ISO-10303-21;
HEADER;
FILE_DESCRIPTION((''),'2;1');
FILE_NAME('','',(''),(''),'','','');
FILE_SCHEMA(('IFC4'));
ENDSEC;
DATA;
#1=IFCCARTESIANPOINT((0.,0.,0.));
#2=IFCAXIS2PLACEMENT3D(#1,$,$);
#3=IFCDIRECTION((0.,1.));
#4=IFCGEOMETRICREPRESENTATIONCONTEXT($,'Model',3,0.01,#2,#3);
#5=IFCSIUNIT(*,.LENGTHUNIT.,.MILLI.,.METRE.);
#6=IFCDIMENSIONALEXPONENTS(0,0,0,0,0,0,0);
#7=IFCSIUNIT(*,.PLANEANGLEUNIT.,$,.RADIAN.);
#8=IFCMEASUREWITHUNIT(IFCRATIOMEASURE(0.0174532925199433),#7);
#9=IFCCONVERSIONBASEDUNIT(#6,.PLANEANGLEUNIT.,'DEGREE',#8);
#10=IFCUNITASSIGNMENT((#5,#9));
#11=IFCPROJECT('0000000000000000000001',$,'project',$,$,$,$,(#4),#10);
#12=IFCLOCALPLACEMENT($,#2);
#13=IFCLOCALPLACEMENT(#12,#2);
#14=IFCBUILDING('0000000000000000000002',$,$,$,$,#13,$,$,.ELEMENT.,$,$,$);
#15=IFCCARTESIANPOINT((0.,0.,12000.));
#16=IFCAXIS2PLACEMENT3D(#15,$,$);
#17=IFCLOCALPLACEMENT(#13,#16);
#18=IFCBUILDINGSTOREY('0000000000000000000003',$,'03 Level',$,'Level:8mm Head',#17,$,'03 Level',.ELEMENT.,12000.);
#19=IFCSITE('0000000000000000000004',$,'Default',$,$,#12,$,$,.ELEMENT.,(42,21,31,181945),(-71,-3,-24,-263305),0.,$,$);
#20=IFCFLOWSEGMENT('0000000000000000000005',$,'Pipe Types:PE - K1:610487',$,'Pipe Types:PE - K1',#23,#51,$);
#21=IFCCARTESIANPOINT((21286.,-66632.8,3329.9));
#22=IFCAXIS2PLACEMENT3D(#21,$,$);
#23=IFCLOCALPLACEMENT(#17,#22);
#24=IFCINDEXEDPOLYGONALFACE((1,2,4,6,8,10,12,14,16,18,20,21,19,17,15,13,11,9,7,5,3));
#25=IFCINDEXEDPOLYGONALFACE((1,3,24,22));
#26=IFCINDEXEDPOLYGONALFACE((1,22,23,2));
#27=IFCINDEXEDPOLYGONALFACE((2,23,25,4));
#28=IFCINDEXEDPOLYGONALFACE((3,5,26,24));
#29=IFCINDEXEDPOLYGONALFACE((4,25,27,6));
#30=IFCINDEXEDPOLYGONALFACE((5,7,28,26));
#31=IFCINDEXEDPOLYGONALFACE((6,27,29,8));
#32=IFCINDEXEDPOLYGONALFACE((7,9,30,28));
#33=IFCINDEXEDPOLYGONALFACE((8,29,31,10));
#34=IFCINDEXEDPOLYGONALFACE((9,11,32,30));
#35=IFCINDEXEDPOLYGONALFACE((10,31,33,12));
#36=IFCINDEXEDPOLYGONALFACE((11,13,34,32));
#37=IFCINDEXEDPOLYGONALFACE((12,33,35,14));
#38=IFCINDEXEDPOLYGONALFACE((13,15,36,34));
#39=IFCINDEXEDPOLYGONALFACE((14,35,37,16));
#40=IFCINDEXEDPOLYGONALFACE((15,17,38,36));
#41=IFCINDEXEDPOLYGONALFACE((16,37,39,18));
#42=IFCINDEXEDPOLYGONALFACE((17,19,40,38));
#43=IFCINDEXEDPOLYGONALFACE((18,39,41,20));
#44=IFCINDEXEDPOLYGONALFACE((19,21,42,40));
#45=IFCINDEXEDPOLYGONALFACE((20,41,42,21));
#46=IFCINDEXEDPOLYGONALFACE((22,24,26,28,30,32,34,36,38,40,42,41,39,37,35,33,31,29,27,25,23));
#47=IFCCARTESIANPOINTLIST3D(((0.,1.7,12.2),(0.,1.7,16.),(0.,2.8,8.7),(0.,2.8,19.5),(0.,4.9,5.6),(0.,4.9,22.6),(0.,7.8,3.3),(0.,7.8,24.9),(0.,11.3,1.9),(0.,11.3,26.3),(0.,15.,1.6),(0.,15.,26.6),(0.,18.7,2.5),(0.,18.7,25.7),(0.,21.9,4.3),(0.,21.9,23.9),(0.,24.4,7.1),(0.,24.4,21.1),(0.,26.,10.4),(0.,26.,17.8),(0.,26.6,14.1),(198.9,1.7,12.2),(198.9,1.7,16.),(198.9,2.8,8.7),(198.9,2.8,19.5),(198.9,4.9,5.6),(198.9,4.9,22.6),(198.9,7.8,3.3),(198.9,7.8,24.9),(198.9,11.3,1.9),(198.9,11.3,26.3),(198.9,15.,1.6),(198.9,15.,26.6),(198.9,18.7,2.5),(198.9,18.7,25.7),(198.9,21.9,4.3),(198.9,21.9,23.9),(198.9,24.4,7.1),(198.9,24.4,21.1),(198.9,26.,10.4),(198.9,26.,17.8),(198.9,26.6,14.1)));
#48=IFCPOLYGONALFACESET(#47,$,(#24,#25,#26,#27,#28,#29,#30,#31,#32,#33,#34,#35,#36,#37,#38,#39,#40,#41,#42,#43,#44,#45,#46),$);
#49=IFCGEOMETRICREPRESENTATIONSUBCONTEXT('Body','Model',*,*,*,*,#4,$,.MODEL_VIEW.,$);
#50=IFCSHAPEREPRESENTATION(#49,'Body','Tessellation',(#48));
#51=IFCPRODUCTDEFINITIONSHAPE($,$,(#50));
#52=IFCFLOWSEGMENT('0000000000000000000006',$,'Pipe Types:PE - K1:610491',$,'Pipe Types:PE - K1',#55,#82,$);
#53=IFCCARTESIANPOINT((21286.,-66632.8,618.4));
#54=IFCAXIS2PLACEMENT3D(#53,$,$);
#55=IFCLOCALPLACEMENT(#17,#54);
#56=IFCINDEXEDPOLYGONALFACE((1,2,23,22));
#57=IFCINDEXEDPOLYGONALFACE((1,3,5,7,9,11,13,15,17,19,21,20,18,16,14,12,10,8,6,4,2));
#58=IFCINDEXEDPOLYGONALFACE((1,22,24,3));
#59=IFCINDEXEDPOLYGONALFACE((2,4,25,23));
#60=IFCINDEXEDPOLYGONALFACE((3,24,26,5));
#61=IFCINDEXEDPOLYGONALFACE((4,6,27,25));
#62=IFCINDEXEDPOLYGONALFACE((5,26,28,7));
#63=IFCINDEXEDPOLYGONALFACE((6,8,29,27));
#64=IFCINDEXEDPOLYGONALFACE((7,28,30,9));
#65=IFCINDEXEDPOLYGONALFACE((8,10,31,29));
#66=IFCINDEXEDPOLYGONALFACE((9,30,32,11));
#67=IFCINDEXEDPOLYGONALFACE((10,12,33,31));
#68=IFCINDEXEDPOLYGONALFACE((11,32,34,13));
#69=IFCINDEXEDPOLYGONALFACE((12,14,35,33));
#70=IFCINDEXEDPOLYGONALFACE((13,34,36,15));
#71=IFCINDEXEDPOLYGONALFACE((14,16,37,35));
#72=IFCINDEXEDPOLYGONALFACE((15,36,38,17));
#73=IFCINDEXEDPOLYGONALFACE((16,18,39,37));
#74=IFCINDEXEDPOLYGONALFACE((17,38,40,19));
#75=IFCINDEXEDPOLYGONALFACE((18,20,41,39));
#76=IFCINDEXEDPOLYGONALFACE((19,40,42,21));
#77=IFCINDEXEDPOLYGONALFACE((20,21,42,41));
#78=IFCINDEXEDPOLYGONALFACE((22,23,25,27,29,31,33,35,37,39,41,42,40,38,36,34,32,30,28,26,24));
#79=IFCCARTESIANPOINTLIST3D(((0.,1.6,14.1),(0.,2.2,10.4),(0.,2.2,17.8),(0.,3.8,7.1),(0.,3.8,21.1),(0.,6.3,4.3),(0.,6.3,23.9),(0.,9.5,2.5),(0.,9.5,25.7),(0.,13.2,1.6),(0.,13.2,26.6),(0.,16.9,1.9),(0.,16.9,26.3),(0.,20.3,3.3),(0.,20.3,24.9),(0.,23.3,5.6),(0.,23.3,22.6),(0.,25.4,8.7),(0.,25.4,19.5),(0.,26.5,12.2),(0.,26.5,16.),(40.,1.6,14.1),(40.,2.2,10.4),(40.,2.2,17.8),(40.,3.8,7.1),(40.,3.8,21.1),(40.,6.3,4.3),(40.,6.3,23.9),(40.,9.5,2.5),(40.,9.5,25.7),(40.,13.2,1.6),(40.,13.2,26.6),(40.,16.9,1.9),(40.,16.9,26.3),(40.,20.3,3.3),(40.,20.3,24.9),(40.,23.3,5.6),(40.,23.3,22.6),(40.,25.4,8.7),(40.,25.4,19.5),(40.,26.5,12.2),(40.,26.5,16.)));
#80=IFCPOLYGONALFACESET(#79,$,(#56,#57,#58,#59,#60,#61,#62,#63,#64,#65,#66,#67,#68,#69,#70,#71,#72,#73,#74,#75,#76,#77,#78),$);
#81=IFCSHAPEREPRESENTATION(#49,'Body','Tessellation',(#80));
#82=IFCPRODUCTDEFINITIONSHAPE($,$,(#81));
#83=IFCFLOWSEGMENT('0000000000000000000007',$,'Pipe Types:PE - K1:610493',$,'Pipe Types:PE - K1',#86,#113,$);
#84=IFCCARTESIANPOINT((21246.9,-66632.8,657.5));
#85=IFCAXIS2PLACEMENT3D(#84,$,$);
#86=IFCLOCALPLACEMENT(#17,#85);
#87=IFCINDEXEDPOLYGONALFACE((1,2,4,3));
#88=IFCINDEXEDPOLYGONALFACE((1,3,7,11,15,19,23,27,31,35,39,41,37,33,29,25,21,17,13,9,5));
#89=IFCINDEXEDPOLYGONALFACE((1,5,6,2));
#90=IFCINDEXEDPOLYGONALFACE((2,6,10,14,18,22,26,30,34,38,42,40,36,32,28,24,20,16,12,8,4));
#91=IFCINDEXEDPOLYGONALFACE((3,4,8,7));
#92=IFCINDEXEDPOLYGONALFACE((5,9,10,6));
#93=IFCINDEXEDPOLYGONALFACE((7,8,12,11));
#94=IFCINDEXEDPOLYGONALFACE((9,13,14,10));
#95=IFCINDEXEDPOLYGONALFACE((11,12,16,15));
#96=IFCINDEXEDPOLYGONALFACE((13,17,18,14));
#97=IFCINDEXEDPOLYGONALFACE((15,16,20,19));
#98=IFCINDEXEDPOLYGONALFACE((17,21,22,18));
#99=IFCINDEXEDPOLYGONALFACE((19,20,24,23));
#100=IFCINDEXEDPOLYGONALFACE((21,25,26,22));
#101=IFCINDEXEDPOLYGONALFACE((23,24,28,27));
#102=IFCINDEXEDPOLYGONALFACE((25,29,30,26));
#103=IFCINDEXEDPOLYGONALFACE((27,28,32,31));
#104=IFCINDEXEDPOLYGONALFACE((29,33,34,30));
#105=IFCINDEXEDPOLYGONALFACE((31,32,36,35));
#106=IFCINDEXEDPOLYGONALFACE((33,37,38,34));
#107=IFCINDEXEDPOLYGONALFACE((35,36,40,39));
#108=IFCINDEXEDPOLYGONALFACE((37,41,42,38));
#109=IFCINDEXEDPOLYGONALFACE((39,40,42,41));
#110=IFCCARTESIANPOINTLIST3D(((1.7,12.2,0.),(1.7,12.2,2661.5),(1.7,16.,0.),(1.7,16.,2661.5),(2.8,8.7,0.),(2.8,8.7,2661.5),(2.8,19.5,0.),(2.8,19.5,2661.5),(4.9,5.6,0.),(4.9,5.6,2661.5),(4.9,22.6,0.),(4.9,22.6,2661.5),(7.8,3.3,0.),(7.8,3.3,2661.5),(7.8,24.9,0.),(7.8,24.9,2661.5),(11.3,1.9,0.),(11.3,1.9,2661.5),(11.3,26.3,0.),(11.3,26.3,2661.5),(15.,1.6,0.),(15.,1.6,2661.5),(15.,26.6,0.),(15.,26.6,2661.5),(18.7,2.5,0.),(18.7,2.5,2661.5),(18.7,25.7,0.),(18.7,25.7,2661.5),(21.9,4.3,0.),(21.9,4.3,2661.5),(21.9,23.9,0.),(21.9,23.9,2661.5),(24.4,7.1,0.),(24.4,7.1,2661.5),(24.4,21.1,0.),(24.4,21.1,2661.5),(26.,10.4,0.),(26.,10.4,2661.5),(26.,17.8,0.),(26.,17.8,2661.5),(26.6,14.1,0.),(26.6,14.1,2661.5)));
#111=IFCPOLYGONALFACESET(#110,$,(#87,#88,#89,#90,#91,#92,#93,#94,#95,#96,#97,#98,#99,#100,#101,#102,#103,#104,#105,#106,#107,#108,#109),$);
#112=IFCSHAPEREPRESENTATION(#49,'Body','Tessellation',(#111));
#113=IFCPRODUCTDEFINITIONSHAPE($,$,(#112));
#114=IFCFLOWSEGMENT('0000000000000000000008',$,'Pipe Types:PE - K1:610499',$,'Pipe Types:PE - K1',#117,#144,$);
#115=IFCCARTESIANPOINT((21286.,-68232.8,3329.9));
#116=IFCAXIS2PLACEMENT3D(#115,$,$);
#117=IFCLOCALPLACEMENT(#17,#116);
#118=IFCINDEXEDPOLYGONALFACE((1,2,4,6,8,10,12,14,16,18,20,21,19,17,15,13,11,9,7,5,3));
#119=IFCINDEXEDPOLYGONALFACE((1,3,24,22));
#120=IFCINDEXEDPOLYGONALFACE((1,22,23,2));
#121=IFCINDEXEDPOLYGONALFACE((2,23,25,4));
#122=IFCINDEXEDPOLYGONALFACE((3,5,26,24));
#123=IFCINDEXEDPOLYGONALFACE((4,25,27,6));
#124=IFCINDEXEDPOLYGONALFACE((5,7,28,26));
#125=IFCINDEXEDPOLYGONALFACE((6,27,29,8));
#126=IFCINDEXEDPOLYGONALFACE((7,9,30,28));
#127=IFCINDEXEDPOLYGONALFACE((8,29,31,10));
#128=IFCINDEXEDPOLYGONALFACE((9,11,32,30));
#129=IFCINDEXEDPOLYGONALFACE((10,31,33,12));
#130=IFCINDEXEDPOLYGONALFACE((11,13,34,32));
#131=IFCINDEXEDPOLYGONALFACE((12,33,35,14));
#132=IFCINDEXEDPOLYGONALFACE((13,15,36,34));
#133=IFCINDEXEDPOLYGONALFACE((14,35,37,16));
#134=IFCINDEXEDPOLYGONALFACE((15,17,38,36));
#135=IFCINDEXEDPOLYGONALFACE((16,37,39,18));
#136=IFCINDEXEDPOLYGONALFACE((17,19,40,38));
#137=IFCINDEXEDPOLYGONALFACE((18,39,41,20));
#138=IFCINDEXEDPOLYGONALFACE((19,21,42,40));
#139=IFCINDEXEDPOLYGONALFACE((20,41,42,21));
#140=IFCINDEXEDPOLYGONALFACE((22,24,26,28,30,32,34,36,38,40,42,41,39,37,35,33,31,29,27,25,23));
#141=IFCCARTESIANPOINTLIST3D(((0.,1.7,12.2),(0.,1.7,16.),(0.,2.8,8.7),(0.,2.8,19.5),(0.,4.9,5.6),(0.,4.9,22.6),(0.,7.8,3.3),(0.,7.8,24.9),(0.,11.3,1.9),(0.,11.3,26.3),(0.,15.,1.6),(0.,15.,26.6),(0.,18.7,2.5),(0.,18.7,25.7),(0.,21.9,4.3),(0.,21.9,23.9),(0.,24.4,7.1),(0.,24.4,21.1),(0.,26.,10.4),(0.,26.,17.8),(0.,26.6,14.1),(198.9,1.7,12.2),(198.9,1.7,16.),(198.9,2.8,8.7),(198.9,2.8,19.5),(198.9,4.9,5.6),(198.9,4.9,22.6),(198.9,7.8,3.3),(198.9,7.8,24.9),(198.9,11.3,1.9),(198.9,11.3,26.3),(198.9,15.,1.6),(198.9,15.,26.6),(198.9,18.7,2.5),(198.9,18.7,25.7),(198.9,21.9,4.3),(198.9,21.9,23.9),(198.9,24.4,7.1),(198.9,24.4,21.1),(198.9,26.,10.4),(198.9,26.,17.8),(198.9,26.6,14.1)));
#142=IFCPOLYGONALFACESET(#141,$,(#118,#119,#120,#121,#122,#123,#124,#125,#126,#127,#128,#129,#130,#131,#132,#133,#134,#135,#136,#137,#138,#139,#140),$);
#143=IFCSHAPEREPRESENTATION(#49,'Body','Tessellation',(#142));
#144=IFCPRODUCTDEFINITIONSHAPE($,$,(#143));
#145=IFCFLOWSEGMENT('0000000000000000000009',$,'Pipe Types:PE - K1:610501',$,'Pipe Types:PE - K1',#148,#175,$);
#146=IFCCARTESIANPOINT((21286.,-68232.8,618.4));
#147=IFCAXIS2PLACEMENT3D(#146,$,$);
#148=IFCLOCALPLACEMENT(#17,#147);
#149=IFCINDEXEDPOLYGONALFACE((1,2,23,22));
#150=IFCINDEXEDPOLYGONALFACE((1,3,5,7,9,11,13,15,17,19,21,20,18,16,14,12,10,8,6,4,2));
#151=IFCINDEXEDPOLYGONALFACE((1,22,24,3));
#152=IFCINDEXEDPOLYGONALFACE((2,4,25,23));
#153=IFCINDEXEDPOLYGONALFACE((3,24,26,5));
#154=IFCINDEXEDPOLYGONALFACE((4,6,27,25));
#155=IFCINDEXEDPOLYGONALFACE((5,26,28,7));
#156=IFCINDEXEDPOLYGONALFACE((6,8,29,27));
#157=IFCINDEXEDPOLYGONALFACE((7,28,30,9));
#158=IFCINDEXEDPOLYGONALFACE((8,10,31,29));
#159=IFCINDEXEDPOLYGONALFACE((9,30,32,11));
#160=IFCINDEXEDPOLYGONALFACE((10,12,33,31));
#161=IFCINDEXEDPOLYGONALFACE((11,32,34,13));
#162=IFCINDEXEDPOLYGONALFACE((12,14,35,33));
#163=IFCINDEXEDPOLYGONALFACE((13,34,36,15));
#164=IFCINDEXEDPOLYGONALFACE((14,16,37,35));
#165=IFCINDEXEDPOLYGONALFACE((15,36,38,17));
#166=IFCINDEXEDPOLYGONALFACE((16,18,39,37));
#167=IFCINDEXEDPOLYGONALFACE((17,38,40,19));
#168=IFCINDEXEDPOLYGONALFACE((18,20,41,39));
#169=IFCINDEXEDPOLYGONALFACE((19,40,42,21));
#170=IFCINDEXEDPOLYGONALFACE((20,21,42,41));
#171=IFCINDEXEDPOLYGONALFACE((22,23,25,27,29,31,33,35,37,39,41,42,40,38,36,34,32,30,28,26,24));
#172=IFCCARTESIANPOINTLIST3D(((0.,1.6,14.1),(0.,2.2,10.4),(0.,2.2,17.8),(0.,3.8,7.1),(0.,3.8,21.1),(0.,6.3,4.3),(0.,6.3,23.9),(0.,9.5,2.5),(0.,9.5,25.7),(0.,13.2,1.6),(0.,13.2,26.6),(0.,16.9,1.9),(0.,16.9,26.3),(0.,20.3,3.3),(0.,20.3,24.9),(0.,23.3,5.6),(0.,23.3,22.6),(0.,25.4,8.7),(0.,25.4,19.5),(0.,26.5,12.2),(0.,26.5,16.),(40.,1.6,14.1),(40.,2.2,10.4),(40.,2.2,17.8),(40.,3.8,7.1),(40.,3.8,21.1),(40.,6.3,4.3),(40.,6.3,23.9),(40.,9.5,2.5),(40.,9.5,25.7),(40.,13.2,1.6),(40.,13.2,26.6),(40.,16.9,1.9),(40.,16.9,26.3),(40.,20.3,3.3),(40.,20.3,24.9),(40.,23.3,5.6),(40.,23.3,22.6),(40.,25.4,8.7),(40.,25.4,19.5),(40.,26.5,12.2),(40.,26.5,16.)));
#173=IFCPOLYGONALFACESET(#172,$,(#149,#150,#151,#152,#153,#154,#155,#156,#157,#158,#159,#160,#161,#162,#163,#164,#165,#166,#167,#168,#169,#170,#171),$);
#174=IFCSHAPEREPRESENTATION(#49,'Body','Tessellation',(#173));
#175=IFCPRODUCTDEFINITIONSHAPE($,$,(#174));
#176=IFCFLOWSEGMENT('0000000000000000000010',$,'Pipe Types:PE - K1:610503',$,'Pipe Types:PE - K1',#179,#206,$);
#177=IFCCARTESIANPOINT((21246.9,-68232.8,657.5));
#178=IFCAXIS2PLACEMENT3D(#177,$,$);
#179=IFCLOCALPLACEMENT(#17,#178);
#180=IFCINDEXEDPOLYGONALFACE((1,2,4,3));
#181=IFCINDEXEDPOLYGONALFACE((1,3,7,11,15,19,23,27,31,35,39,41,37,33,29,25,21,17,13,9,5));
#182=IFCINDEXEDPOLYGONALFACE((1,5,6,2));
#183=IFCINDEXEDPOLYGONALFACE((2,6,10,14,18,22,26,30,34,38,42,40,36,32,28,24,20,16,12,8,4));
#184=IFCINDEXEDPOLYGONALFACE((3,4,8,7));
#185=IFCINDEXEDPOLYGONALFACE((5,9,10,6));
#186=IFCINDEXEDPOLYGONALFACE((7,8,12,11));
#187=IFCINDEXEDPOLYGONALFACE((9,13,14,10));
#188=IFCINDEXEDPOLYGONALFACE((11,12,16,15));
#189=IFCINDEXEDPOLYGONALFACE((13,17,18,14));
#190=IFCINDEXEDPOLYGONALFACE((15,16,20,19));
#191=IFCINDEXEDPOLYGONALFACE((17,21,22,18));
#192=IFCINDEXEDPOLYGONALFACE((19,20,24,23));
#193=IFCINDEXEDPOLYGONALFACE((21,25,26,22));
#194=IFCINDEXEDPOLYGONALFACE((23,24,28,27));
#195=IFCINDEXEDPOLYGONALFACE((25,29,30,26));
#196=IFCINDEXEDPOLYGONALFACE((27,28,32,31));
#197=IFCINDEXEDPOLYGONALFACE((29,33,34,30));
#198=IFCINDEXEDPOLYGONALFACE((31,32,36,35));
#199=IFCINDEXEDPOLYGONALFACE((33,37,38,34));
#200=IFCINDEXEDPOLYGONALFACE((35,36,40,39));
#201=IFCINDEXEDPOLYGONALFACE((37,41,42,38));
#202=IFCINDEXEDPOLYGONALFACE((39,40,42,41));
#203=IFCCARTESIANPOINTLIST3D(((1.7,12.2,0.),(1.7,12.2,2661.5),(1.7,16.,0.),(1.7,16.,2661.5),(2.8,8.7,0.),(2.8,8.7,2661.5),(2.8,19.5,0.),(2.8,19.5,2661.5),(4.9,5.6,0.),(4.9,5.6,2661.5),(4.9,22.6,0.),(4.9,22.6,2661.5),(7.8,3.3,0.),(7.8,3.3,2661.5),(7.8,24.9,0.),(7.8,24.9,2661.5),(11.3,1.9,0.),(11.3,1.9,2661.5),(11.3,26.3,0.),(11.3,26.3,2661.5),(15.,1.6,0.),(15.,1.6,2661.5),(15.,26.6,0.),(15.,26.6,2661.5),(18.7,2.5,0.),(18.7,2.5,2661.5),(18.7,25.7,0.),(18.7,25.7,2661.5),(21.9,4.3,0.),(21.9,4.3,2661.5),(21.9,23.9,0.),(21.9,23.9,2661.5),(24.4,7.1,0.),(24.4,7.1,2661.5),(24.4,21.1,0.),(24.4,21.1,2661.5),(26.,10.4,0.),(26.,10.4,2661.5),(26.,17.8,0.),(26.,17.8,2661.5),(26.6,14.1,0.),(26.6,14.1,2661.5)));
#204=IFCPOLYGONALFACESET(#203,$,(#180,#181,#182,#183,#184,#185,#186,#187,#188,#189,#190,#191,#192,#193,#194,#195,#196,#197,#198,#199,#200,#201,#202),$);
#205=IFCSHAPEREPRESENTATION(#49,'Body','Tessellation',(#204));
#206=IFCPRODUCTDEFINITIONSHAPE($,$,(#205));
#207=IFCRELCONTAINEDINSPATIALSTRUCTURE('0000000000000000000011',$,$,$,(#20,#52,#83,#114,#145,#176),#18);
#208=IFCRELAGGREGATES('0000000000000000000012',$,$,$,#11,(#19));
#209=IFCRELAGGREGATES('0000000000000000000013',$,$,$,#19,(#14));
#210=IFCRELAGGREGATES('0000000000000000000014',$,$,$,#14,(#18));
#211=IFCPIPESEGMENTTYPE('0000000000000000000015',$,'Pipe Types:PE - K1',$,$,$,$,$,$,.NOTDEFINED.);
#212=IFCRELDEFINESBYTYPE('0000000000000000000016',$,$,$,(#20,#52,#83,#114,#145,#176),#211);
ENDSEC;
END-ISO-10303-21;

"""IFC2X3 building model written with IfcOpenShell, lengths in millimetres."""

from ifc_helpers import new_model, entity, si_unit, converted_unit, direction, frame, frame_2d, origin, origin_2d_with_axis, place, context, subcontext, project, spatial, circle, extrude, type_object, element, save


model = new_model("IFC2X3")

# Units and contexts
model_context = context("Model", 3, precision=0.01, world=origin(), true_north=direction((0.0, 1.0)))
body_context = subcontext(model_context, "Body", "Model", "MODEL_VIEW")
ifc_project = project(units=[si_unit("LENGTHUNIT", "METRE", prefix="MILLI"), converted_unit("PLANEANGLEUNIT", "DEGREE", entity("IfcRatioMeasure", 0.0174532925199433), si_unit("PLANEANGLEUNIT", "RADIAN"), dimensions=[0, 0, 0, 0, 0, 0, 0])], contexts=[model_context])

# Site, building, storey
site_placement = place(None, origin())
site = spatial("IfcSite", under=ifc_project, at=site_placement, Name="Default", CompositionType="ELEMENT", RefLatitude=(42, 21, 31, 181945), RefLongitude=(-71, -3, -24, -263305), RefElevation=0.0)
building_placement = place(site_placement, origin())
building = spatial("IfcBuilding", under=site, at=building_placement, CompositionType="ELEMENT")
storey_placement = place(building_placement, frame((0.0, 0.0, 12000.0)))
storey = spatial("IfcBuildingStorey", under=building, at=storey_placement, Name="03 Level", ObjectType="Level:8mm Head", LongName="03 Level", CompositionType="ELEMENT", Elevation=12000.0)

# Flow segments
pipe_segment_type = type_object("IfcPipeSegmentType", Name="Pipe Types:PE - K1", PredefinedType="NOTDEFINED")
flow_segment_1_placement = place(storey_placement, frame((21286.0, -66632.8, 3329.9)))
element("IfcFlowSegment", 1, at=flow_segment_1_placement, inside=storey, type_object=pipe_segment_type, Name="Pipe Types:PE - K1:610487", ObjectType="Pipe Types:PE - K1", context=body_context, shape_type="SweptSolid", body=[
    extrude(circle(Radius=12.5, at=frame_2d((0.0, 0.0), x_axis=(1.0, 0.0))), frame((0.0, 14.1, 14.1), z_axis=(1.0, 0.0, 0.0), x_axis=(0.0, 1.0, 0.0)), (0.0, 0.0, 1.0), 198.9),
])
flow_segment_2_placement = place(storey_placement, frame((21286.0, -66632.8, 618.4)))
element("IfcFlowSegment", 2, at=flow_segment_2_placement, inside=storey, type_object=pipe_segment_type, Name="Pipe Types:PE - K1:610491", ObjectType="Pipe Types:PE - K1", context=body_context, shape_type="SweptSolid", body=[
    extrude(circle(Radius=12.5, at=origin_2d_with_axis()), frame((0.0, 14.1, 14.1), z_axis=(1.0, 0.0, 0.0), x_axis=(0.0, -1.0, 0.0)), (0.0, 0.0, 1.0), 40.0),
])
flow_segment_3_placement = place(storey_placement, frame((21246.9, -66632.8, 657.5)))
element("IfcFlowSegment", 3, at=flow_segment_3_placement, inside=storey, type_object=pipe_segment_type, Name="Pipe Types:PE - K1:610493", ObjectType="Pipe Types:PE - K1", context=body_context, shape_type="SweptSolid", body=[
    extrude(circle(Radius=12.5, at=origin_2d_with_axis()), frame((14.1, 14.1, 0.0)), (0.0, 0.0, 1.0), 2661.5),
])
flow_segment_4_placement = place(storey_placement, frame((21286.0, -68232.8, 3329.9)))
element("IfcFlowSegment", 4, at=flow_segment_4_placement, inside=storey, type_object=pipe_segment_type, Name="Pipe Types:PE - K1:610499", ObjectType="Pipe Types:PE - K1", context=body_context, shape_type="SweptSolid", body=[
    extrude(circle(Radius=12.5, at=frame_2d((0.0, 0.0), x_axis=(1.0, 0.0))), frame((0.0, 14.1, 14.1), z_axis=(1.0, 0.0, 0.0), x_axis=(0.0, 1.0, 0.0)), (0.0, 0.0, 1.0), 198.9),
])
flow_segment_5_placement = place(storey_placement, frame((21286.0, -68232.8, 618.4)))
element("IfcFlowSegment", 5, at=flow_segment_5_placement, inside=storey, type_object=pipe_segment_type, Name="Pipe Types:PE - K1:610501", ObjectType="Pipe Types:PE - K1", context=body_context, shape_type="SweptSolid", body=[
    extrude(circle(Radius=12.5, at=origin_2d_with_axis()), frame((0.0, 14.1, 14.1), z_axis=(1.0, 0.0, 0.0), x_axis=(0.0, -1.0, 0.0)), (0.0, 0.0, 1.0), 40.0),
])
flow_segment_6_placement = place(storey_placement, frame((21246.9, -68232.8, 657.5)))
element("IfcFlowSegment", 6, at=flow_segment_6_placement, inside=storey, type_object=pipe_segment_type, Name="Pipe Types:PE - K1:610503", ObjectType="Pipe Types:PE - K1", context=body_context, shape_type="SweptSolid", body=[
    extrude(circle(Radius=12.5, at=origin_2d_with_axis()), frame((14.1, 14.1, 0.0)), (0.0, 0.0, 1.0), 2661.5),
])

save(model, "model.ifc")
